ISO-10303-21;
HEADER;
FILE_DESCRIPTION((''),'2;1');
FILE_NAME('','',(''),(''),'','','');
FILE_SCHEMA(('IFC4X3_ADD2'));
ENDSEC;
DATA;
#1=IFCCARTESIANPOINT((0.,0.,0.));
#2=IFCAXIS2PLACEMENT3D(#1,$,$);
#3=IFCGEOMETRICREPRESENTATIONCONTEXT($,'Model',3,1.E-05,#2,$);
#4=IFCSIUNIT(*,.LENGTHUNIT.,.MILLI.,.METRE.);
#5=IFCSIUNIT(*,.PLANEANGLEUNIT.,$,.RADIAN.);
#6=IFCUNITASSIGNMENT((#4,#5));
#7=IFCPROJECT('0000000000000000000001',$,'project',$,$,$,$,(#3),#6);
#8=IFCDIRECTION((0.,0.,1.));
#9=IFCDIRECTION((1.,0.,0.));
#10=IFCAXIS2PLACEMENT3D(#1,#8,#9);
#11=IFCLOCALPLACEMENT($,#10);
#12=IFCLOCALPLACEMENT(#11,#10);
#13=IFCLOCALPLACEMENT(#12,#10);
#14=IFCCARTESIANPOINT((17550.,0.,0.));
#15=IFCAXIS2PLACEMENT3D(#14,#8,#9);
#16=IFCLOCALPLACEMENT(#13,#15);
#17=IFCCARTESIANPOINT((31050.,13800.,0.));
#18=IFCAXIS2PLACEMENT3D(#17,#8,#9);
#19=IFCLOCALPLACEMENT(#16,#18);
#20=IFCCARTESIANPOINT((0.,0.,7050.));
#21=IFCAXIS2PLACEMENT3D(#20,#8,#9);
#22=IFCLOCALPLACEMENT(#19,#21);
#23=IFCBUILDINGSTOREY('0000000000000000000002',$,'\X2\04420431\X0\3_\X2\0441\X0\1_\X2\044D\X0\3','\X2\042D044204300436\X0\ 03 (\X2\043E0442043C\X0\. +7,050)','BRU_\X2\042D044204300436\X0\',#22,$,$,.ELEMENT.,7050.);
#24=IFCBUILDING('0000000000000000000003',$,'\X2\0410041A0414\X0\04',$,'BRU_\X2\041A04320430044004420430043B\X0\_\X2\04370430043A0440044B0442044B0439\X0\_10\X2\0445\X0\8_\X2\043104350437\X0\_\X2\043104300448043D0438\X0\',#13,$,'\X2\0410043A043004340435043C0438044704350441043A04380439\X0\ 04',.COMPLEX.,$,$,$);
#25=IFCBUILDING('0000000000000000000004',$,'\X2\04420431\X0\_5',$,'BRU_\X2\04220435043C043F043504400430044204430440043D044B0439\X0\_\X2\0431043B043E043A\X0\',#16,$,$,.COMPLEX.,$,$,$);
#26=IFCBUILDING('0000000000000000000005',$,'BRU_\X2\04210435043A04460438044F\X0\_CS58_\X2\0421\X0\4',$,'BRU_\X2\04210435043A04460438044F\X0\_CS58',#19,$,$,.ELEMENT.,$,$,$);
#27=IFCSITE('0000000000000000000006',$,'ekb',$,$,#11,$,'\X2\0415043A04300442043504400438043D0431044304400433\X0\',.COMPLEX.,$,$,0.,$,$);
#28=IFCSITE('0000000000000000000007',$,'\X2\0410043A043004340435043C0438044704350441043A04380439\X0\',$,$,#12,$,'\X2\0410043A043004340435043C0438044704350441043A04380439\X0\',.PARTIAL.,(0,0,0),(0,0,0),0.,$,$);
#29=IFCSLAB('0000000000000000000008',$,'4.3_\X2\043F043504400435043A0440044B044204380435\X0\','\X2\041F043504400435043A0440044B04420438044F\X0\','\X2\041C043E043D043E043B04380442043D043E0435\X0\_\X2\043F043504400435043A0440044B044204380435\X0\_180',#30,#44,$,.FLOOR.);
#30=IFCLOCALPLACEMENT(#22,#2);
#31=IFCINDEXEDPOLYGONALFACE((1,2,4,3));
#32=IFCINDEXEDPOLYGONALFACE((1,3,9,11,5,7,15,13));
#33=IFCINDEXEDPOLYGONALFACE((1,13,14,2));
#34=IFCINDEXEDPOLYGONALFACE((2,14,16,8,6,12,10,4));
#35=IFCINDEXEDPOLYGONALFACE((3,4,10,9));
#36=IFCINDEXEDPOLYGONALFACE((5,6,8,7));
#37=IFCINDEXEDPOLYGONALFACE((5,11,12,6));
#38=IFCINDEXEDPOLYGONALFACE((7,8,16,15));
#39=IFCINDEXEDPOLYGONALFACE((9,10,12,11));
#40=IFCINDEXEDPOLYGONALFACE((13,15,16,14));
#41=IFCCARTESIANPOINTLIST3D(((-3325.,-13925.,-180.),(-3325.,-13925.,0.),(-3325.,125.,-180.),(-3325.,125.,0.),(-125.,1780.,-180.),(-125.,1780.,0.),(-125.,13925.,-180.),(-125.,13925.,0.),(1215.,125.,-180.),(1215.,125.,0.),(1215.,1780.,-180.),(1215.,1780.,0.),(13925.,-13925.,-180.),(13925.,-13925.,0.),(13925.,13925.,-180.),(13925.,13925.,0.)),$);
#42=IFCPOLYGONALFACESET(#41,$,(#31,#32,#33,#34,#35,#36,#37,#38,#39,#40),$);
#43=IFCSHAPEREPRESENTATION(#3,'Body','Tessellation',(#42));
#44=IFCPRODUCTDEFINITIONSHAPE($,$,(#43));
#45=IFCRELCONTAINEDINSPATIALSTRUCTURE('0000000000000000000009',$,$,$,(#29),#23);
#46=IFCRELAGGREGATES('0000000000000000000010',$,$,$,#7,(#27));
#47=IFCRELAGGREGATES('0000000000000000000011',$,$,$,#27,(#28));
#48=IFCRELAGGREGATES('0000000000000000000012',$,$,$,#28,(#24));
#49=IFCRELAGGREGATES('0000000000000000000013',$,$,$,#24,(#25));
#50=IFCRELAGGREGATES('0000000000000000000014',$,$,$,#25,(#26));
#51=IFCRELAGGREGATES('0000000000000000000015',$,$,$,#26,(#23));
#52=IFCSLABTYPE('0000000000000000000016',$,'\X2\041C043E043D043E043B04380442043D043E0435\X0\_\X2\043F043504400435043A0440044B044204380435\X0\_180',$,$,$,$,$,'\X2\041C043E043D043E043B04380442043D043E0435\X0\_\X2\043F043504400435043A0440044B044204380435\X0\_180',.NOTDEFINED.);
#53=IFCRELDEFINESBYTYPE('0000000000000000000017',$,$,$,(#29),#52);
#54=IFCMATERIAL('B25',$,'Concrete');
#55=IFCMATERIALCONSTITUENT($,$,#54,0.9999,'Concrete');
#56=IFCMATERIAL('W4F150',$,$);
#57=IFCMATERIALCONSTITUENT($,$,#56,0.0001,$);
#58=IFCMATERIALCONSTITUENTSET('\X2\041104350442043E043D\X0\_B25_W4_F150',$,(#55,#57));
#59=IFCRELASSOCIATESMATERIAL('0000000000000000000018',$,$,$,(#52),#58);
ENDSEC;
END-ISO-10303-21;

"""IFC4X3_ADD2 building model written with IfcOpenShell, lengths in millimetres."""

from ifc_helpers import new_model, si_unit, frame, origin, origin_with_axes, place, context, project, spatial, polyline, outline, extrude, material, constituent, constituent_set, type_object, element, save


model = new_model("IFC4X3_ADD2")

# Units and contexts
model_context = context("Model", 3, precision=1e-05, world=origin())
ifc_project = project(units=[si_unit("LENGTHUNIT", "METRE", prefix="MILLI"), si_unit("PLANEANGLEUNIT", "RADIAN")], contexts=[model_context])

# Sites, buildings, storey
site_1_placement = place(None, origin_with_axes())
site_1 = spatial("IfcSite", under=ifc_project, at=site_1_placement, Name="ekb", LongName="Екатеринбург", CompositionType="COMPLEX", RefElevation=0.0)
site_2_placement = place(site_1_placement, origin_with_axes())
site_2 = spatial("IfcSite", under=site_1, at=site_2_placement, Name="Академический", LongName="Академический", CompositionType="PARTIAL", RefLatitude=(0, 0, 0), RefLongitude=(0, 0, 0), RefElevation=0.0)
building_1_placement = place(site_2_placement, origin_with_axes())
building_1 = spatial("IfcBuilding", under=site_2, at=building_1_placement, Name="АКД04", ObjectType="BRU_Квартал_закрытый_10х8_без_башни", LongName="Академический 04", CompositionType="COMPLEX")
building_2_placement = place(building_1_placement, frame((17550.0, 0.0, 0.0), z_axis=(0.0, 0.0, 1.0), x_axis=(1.0, 0.0, 0.0)))
building_2 = spatial("IfcBuilding", under=building_1, at=building_2_placement, Name="тб_5", ObjectType="BRU_Температурный_блок", CompositionType="COMPLEX")
building_3_placement = place(building_2_placement, frame((31050.0, 13800.0, 0.0), z_axis=(0.0, 0.0, 1.0), x_axis=(1.0, 0.0, 0.0)))
building_3 = spatial("IfcBuilding", under=building_2, at=building_3_placement, Name="BRU_Секция_CS58_С4", ObjectType="BRU_Секция_CS58", CompositionType="ELEMENT")
storey_placement = place(building_3_placement, frame((0.0, 0.0, 7050.0), z_axis=(0.0, 0.0, 1.0), x_axis=(1.0, 0.0, 0.0)))
storey = spatial("IfcBuildingStorey", under=building_3, at=storey_placement, Name="тб3_с1_э3", Description="Этаж 03 (отм. +7,050)", ObjectType="BRU_Этаж", CompositionType="ELEMENT", Elevation=7050.0)

# Shared definitions
ifc_material_1 = material(Name="B25", Category="Concrete")
ifc_material_2 = material(Name="W4F150")

# Slab
ifc_constituent_1 = constituent(ifc_material_1, Category="Concrete", fraction=0.9999)
ifc_constituent_2 = constituent(ifc_material_2, fraction=0.0001)
ifc_constituent_set_1 = constituent_set(constituents=[ifc_constituent_1, ifc_constituent_2], Name="Бетон_B25_W4_F150")
slab_type = type_object("IfcSlabType", Name="Монолитное_перекрытие_180", ElementType="Монолитное_перекрытие_180", PredefinedType="NOTDEFINED", material=ifc_constituent_set_1)
slab_placement = place(storey_placement, frame((0.0, 0.0, -180.0), z_axis=(0.0, 0.0, 1.0), x_axis=(1.0, 0.0, 0.0)))
element("IfcSlab", 1, at=slab_placement, inside=storey, type_object=slab_type, Name="4.3_перекрытие", Description="Перекрытия", ObjectType="Монолитное_перекрытие_180", PredefinedType="FLOOR", context=model_context, shape_type="SweptSolid", body=[
    extrude(outline(polyline([(13925.0, -13925.0), (13925.0, 13925.0), (-125.0, 13925.0), (-125.0, 1780.0), (1215.0, 1780.0), (1215.0, 125.0), (-3325.0, 125.0), (-3325.0, -13925.0), (13925.0, -13925.0)])), origin_with_axes(), (0.0, 0.0, 1.0), 180.0),
])

save(model, "model.ifc")
